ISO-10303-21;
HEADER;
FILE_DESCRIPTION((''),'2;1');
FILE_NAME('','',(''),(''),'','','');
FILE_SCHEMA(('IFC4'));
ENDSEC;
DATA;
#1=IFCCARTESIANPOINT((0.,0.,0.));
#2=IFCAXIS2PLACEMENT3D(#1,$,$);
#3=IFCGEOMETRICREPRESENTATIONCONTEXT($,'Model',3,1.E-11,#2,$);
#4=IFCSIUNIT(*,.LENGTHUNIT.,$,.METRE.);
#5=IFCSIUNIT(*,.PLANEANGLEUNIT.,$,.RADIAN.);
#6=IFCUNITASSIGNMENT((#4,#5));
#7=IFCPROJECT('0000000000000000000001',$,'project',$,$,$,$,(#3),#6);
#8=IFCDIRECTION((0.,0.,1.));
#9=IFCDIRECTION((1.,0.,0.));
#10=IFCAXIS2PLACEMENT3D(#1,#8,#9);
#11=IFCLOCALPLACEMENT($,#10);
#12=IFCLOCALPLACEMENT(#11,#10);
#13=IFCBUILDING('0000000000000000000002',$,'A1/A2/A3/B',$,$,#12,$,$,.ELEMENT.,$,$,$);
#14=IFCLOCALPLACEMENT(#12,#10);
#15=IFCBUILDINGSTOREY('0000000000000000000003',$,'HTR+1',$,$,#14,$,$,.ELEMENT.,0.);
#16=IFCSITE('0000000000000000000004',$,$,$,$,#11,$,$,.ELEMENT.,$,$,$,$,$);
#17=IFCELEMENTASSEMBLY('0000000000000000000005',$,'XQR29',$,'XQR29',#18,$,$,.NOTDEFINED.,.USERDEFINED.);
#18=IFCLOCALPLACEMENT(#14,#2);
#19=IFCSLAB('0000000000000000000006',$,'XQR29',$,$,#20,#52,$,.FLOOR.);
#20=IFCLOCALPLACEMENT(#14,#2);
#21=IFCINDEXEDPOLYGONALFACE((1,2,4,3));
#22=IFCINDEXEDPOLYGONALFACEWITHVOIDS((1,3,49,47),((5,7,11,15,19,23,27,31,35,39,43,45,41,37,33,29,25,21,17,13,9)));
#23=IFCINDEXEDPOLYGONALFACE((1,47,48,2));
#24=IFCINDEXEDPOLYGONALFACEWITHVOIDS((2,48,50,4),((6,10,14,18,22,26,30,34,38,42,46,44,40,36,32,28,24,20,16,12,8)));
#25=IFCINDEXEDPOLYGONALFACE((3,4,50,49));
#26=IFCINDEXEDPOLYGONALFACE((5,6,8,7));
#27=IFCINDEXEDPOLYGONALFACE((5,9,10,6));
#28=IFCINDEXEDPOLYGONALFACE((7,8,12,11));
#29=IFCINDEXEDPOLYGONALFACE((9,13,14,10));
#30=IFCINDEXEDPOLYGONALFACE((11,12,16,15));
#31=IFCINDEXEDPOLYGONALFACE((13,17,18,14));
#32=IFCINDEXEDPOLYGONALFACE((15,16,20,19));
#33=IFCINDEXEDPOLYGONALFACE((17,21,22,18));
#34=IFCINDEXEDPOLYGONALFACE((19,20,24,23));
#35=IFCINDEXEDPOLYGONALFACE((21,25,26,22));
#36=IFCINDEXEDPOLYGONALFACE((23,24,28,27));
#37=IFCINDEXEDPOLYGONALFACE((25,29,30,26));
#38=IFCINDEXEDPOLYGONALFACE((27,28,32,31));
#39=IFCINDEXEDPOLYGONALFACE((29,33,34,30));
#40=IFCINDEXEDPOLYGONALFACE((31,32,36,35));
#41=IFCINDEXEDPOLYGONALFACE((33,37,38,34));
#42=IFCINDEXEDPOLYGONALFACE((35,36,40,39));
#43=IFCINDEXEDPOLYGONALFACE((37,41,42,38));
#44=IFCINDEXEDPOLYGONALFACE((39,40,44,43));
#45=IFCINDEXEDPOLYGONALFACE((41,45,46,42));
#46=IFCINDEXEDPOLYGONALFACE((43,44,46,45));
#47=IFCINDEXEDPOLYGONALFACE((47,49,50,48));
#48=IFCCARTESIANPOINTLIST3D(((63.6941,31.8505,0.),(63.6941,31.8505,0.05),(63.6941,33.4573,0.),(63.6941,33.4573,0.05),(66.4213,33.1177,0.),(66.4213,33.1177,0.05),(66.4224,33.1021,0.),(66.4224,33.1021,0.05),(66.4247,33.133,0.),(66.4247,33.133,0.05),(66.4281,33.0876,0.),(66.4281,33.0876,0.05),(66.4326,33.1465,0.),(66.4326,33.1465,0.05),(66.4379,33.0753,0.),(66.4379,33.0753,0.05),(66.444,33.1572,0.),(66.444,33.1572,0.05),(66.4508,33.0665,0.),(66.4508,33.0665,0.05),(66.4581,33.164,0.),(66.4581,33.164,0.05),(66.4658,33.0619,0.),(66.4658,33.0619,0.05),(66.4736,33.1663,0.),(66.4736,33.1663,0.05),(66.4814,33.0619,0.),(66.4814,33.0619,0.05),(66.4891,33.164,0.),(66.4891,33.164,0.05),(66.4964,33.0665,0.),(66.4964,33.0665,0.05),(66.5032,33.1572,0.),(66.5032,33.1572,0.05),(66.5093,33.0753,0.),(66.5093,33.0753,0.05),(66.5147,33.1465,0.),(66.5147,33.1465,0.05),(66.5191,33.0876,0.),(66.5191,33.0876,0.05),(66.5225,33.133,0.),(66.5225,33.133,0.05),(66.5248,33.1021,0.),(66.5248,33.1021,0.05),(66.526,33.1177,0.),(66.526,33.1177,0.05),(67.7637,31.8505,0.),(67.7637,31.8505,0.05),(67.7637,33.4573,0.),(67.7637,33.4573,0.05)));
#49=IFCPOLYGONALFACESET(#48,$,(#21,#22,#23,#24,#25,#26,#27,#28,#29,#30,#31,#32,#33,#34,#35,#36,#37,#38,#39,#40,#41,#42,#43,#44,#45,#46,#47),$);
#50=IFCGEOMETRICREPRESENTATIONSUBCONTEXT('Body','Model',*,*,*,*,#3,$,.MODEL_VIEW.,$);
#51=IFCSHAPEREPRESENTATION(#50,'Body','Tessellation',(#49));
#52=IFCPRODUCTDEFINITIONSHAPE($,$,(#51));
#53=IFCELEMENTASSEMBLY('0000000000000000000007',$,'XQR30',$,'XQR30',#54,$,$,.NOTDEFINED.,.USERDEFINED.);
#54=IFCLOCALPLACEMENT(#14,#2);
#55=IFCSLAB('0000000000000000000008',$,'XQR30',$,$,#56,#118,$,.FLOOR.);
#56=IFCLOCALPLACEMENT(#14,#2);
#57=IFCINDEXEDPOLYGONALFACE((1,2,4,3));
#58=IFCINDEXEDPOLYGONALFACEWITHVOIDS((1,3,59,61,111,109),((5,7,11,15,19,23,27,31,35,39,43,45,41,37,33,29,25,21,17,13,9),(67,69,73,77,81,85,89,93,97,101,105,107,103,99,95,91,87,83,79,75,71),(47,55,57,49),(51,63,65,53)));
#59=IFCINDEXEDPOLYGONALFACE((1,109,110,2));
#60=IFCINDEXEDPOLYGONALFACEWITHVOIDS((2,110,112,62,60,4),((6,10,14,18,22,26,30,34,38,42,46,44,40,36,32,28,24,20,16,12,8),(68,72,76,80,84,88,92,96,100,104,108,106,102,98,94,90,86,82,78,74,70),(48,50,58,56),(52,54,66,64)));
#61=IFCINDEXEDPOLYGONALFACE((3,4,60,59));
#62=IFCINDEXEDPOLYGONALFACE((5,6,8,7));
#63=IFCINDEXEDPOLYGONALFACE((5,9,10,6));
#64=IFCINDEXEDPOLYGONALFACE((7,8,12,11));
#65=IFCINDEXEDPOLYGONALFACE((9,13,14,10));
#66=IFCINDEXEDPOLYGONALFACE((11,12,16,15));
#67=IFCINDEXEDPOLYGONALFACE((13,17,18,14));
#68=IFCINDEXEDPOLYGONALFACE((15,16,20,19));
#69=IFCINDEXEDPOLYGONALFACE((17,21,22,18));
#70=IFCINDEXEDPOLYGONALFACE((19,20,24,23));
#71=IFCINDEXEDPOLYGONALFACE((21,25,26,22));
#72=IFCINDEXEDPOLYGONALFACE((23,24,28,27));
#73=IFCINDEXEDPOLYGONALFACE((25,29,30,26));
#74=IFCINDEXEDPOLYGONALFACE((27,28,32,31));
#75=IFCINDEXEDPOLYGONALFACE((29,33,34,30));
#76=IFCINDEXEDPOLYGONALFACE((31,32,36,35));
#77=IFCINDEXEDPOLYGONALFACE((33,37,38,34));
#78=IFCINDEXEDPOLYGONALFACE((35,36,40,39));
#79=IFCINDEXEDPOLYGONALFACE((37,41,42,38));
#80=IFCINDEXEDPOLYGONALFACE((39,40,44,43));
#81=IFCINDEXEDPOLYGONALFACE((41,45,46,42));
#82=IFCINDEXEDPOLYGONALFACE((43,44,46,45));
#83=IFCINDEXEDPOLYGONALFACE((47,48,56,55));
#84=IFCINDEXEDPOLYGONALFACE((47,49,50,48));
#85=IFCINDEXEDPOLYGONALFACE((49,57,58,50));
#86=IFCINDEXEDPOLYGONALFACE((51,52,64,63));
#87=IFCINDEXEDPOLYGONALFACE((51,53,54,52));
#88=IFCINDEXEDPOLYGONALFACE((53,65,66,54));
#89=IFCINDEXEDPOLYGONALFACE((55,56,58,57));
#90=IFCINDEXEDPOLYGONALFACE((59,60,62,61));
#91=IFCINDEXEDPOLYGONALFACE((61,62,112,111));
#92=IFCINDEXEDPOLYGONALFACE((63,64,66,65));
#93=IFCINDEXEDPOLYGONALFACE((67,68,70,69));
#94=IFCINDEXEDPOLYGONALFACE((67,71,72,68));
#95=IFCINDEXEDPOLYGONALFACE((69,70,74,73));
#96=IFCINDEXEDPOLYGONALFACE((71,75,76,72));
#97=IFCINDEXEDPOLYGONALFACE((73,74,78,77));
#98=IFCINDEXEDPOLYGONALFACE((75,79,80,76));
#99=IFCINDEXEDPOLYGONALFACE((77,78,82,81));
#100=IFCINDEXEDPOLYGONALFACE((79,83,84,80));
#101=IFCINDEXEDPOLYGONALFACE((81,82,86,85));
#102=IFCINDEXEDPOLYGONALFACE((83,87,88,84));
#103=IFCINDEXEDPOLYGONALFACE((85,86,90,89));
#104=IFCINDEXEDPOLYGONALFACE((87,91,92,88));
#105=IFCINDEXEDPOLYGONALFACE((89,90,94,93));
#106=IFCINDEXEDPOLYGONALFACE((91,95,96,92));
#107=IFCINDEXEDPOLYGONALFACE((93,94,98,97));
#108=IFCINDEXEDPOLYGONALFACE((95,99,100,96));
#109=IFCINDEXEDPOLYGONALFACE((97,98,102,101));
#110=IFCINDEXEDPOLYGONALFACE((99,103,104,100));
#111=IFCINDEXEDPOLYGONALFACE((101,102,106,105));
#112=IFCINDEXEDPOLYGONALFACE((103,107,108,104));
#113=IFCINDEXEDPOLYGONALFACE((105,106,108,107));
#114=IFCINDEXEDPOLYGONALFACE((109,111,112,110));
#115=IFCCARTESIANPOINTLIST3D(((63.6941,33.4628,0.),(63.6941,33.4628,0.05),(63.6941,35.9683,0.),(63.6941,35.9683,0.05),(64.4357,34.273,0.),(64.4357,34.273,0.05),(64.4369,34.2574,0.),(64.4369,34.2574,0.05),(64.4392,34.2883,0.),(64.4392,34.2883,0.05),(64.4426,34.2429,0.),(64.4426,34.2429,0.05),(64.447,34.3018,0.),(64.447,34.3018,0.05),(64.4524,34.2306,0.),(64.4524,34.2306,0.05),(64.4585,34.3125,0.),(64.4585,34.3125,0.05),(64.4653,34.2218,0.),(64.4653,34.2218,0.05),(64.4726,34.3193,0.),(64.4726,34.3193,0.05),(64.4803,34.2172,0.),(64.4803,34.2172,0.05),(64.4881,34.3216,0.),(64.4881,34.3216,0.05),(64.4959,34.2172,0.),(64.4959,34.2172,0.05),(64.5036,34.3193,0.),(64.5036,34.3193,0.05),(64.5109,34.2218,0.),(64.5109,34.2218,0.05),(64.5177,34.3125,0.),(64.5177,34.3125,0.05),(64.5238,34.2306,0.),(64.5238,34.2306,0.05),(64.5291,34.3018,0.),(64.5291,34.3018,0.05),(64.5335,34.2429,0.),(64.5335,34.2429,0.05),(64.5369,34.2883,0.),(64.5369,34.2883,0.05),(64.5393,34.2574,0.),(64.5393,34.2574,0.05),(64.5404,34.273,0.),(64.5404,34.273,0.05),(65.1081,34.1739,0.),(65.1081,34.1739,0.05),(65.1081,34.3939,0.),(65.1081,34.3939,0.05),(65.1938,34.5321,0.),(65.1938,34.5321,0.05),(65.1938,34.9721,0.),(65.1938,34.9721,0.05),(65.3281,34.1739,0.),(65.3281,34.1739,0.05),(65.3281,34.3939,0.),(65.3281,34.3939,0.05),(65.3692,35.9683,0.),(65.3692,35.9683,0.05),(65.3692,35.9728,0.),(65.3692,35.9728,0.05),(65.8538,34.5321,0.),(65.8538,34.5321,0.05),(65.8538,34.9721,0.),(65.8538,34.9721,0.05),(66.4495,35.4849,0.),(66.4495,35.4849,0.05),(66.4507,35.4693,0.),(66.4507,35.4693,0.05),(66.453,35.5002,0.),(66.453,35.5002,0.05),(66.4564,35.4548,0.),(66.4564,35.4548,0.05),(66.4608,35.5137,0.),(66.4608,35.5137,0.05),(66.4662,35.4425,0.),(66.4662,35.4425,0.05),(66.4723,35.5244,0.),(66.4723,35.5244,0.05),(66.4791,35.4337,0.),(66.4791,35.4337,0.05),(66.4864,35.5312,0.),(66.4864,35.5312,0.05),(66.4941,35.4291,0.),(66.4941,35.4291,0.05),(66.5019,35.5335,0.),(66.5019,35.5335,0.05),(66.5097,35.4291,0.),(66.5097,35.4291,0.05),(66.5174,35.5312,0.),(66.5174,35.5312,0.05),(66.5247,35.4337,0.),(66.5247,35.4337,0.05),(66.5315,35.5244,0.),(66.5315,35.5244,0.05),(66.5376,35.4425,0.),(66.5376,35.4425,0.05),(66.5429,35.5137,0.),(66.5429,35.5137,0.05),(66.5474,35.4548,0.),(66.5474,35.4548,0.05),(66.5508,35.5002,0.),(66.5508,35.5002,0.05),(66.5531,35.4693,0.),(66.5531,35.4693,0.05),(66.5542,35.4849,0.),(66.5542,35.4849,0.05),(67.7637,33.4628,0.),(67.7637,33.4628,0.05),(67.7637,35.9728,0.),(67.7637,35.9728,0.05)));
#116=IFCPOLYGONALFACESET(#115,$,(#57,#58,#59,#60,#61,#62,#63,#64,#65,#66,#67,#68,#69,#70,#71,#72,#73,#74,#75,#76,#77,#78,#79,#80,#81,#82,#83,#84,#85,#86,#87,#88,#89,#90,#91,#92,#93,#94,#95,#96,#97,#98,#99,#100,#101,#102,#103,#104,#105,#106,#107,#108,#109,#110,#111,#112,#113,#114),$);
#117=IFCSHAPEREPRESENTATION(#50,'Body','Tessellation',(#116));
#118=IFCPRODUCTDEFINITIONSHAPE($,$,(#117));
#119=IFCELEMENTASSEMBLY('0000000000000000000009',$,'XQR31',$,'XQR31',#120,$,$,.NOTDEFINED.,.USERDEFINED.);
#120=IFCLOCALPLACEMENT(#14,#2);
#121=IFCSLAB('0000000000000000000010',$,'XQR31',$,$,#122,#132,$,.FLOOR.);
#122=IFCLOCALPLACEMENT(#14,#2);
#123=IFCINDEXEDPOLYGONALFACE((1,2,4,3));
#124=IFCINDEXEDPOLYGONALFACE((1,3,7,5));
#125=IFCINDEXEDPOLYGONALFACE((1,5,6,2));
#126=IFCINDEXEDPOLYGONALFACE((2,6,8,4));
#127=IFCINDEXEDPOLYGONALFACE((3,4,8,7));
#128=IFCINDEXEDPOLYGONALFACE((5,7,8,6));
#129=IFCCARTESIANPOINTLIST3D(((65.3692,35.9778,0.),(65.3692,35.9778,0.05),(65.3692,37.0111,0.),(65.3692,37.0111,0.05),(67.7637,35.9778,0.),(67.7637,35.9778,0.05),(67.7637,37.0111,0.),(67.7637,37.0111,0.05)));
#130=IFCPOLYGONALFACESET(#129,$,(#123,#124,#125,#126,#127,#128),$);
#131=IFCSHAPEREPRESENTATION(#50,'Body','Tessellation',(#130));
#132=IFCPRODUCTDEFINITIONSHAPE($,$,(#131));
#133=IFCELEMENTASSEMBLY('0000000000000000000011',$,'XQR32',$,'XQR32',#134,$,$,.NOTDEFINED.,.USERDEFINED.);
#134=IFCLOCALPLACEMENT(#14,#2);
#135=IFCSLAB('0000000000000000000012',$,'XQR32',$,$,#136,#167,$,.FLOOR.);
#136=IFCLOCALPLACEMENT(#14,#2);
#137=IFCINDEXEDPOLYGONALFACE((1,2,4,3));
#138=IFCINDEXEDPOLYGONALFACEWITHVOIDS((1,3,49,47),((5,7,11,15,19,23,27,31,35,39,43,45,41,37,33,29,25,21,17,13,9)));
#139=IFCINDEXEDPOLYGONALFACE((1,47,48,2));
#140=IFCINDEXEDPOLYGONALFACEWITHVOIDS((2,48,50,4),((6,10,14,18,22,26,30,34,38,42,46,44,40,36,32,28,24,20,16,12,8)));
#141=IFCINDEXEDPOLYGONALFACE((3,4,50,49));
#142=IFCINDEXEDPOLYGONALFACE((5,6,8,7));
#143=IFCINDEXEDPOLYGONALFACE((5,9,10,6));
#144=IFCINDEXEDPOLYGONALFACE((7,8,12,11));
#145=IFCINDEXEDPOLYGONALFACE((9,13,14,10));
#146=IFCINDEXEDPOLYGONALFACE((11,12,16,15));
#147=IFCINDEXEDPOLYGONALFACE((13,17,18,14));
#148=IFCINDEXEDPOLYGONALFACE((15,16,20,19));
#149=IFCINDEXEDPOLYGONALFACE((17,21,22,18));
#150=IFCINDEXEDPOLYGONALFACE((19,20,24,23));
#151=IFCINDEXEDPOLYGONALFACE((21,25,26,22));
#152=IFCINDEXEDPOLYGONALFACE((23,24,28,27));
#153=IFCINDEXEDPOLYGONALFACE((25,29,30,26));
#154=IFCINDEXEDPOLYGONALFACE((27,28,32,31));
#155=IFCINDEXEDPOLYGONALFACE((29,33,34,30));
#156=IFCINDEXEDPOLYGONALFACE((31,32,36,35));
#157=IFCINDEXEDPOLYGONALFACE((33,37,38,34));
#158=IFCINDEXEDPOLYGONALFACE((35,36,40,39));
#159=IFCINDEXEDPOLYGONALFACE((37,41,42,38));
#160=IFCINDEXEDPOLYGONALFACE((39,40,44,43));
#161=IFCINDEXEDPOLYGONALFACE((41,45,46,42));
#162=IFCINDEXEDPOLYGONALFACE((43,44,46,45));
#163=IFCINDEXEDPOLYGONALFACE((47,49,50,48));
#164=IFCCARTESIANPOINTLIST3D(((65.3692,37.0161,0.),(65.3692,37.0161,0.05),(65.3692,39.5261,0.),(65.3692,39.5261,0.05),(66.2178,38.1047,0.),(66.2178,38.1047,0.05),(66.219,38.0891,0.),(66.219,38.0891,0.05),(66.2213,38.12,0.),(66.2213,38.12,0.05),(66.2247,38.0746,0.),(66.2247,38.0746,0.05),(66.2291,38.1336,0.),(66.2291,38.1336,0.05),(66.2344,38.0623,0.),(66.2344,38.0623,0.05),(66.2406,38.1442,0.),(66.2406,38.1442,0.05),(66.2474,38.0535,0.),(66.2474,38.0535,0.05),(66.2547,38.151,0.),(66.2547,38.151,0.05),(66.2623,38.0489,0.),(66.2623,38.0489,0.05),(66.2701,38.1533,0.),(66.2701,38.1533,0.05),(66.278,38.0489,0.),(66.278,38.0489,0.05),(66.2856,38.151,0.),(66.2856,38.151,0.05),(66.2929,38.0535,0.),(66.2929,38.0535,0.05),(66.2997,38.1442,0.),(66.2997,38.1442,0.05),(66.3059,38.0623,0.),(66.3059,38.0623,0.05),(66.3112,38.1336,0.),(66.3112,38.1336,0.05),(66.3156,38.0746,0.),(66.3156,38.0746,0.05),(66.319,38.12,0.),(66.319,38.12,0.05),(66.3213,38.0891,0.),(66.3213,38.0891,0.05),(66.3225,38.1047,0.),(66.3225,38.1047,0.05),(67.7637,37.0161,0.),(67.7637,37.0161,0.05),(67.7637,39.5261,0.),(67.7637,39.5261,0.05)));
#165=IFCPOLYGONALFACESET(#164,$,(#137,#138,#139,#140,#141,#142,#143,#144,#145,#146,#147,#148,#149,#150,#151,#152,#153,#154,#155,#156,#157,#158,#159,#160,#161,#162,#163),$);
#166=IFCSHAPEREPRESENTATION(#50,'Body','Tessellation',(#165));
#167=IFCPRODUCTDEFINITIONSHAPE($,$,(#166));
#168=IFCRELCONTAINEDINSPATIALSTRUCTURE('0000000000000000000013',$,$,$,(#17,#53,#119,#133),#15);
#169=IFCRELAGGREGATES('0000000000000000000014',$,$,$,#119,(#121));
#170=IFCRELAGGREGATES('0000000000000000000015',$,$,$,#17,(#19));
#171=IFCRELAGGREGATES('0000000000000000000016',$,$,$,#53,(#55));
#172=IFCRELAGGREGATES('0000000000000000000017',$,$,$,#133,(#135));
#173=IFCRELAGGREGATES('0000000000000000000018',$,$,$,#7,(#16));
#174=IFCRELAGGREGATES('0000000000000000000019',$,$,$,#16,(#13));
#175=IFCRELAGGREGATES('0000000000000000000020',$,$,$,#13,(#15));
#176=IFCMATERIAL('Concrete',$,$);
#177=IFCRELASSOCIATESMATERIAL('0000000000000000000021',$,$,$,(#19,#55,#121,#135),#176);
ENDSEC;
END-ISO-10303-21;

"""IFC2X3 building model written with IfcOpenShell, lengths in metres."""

from ifc_helpers import new_model, si_unit, frame, origin, origin_with_axes, origin_2d_with_axis, place, context, subcontext, project, spatial, polyline, circle, outline, extrude, material, element, aggregate, save


model = new_model("IFC2X3")

# Units and contexts
model_context = context("Model", 3, precision=1e-11, world=origin())
body_context = subcontext(model_context, "Body", "Model", "MODEL_VIEW")
ifc_project = project(units=[si_unit("LENGTHUNIT", "METRE"), si_unit("PLANEANGLEUNIT", "RADIAN")], contexts=[model_context])

# Site, building, storey
site_placement = place(None, origin_with_axes())
site = spatial("IfcSite", under=ifc_project, at=site_placement, CompositionType="ELEMENT")
building_placement = place(site_placement, origin_with_axes())
building = spatial("IfcBuilding", under=site, at=building_placement, Name="A1/A2/A3/B", CompositionType="ELEMENT")
storey_placement = place(building_placement, origin_with_axes())
storey = spatial("IfcBuildingStorey", under=building, at=storey_placement, Name="HTR+1", CompositionType="ELEMENT", Elevation=0.0)

# Element assembly, slab, opening
assembly_1_placement = place(storey_placement, origin_with_axes())
assembly_1 = element("IfcElementAssembly", 1, at=assembly_1_placement, inside=storey, Name="XQR29", ObjectType="XQR29", AssemblyPlace="NOTDEFINED", PredefinedType="USERDEFINED")
ifc_material = material(Name="Concrete")
slab_1_placement = place(assembly_1_placement, frame((63.6941, 31.8505, 0.0), z_axis=(0.0, 0.0, 1.0), x_axis=(1.0, 0.0, 0.0)))
slab_1 = element("IfcSlab", 2, at=slab_1_placement, material=ifc_material, Name="XQR29", PredefinedType="FLOOR", context=body_context, shape_type="SweptSolid", body=[
    extrude(outline(polyline([(0.0, 0.0), (0.0, -4.0697), (1.6068, -4.0697), (1.6068, 0.0), (0.0, 0.0)])), frame((0.0, 0.0, 0.0), z_axis=(0.0, 0.0, 1.0), x_axis=(0.0, 1.0, 0.0)), (0.0, 0.0, 1.0), 0.05),
])
opening_1_placement = place(slab_1_placement, frame((2.7795, 1.2633, 0.0), z_axis=(0.0, 0.0, 1.0), x_axis=(1.0, 0.0, 0.0)))
element("IfcOpeningElement", 3, at=opening_1_placement, cuts=slab_1, ObjectType="Opening", context=body_context, shape_type="SweptSolid", body=[
    extrude(circle(Radius=0.0525, at=origin_2d_with_axis()), frame((0.0, 0.0, 0.0), z_axis=(0.0, 0.0, 1.0), x_axis=(0.0, 1.0, 0.0)), (0.0, 0.0, 1.0), 0.05),
])

# Element assembly, slab, openings
assembly_2_placement = place(storey_placement, origin_with_axes())
assembly_2 = element("IfcElementAssembly", 4, at=assembly_2_placement, inside=storey, Name="XQR30", ObjectType="XQR30", AssemblyPlace="NOTDEFINED", PredefinedType="USERDEFINED")
slab_2_placement = place(assembly_2_placement, frame((63.6941, 33.4628, 0.0), z_axis=(0.0, 0.0, 1.0), x_axis=(1.0, 0.0, 0.0)))
slab_2 = element("IfcSlab", 5, at=slab_2_placement, material=ifc_material, Name="XQR30", PredefinedType="FLOOR", context=body_context, shape_type="SweptSolid", body=[
    extrude(outline(polyline([(0.0, 0.0), (0.0, -4.0697), (2.51, -4.0697), (2.51, -1.6751), (2.5055, -1.6751), (2.5055, 0.0), (0.0, 0.0)])), frame((0.0, 0.0, 0.0), z_axis=(0.0, 0.0, 1.0), x_axis=(0.0, 1.0, 0.0)), (0.0, 0.0, 1.0), 0.05),
])
opening_2_placement = place(slab_2_placement, origin_with_axes())
element("IfcOpeningElement", 6, at=opening_2_placement, cuts=slab_2, ObjectType="Opening", context=body_context, shape_type="SweptSolid", body=[
    extrude(outline(polyline([(1.0693, -1.4997), (1.0693, -2.1597), (1.5093, -2.1597), (1.5093, -1.4997), (1.0693, -1.4997)])), frame((0.0, 0.0, 0.0), z_axis=(0.0, 0.0, 1.0), x_axis=(0.0, 1.0, 0.0)), (0.0, 0.0, 1.0), 0.05),
])
opening_3_placement = place(slab_2_placement, origin_with_axes())
element("IfcOpeningElement", 7, at=opening_3_placement, cuts=slab_2, ObjectType="Opening", context=body_context, shape_type="SweptSolid", body=[
    extrude(outline(polyline([(0.7111, -1.414), (0.7111, -1.634), (0.9311, -1.634), (0.9311, -1.414), (0.7111, -1.414)])), frame((0.0, 0.0, 0.0), z_axis=(0.0, 0.0, 1.0), x_axis=(0.0, 1.0, 0.0)), (0.0, 0.0, 1.0), 0.05),
])
opening_4_placement = place(slab_2_placement, frame((2.8078, 2.0182, 0.0), z_axis=(0.0, 0.0, 1.0), x_axis=(1.0, 0.0, 0.0)))
element("IfcOpeningElement", 8, at=opening_4_placement, cuts=slab_2, ObjectType="Opening", context=body_context, shape_type="SweptSolid", body=[
    extrude(circle(Radius=0.0525, at=origin_2d_with_axis()), frame((0.0, 0.0, 0.0), z_axis=(0.0, 0.0, 1.0), x_axis=(0.0, 1.0, 0.0)), (0.0, 0.0, 1.0), 0.05),
])
opening_5_placement = place(slab_2_placement, frame((0.794, 0.8063, 0.0), z_axis=(0.0, 0.0, 1.0), x_axis=(1.0, 0.0, 0.0)))
element("IfcOpeningElement", 9, at=opening_5_placement, cuts=slab_2, ObjectType="Opening", context=body_context, shape_type="SweptSolid", body=[
    extrude(circle(Radius=0.0525, at=origin_2d_with_axis()), frame((0.0, 0.0, 0.0), z_axis=(0.0, 0.0, 1.0), x_axis=(0.0, 1.0, 0.0)), (0.0, 0.0, 1.0), 0.05),
])

# Element assembly, slab
assembly_3_placement = place(storey_placement, origin_with_axes())
assembly_3 = element("IfcElementAssembly", 10, at=assembly_3_placement, inside=storey, Name="XQR31", ObjectType="XQR31", AssemblyPlace="NOTDEFINED", PredefinedType="USERDEFINED")
slab_3_placement = place(assembly_3_placement, frame((65.3692, 35.9778, 0.0), z_axis=(0.0, 0.0, 1.0), x_axis=(1.0, 0.0, 0.0)))
slab_3 = element("IfcSlab", 11, at=slab_3_placement, material=ifc_material, Name="XQR31", PredefinedType="FLOOR", context=body_context, shape_type="SweptSolid", body=[
    extrude(outline(polyline([(0.0, 0.0), (0.0, -2.3946), (1.0333, -2.3946), (1.0333, 0.0), (0.0, 0.0)])), frame((0.0, 0.0, 0.0), z_axis=(0.0, 0.0, 1.0), x_axis=(0.0, 1.0, 0.0)), (0.0, 0.0, 1.0), 0.05),
])
aggregate(assembly_3, [slab_3])

# Element assembly, slab, opening
assembly_4_placement = place(storey_placement, origin_with_axes())
assembly_4 = element("IfcElementAssembly", 12, at=assembly_4_placement, inside=storey, Name="XQR32", ObjectType="XQR32", AssemblyPlace="NOTDEFINED", PredefinedType="USERDEFINED")
slab_4_placement = place(assembly_4_placement, frame((65.3692, 37.0161, 0.0), z_axis=(0.0, 0.0, 1.0), x_axis=(1.0, 0.0, 0.0)))
slab_4 = element("IfcSlab", 13, at=slab_4_placement, material=ifc_material, Name="XQR32", PredefinedType="FLOOR", context=body_context, shape_type="SweptSolid", body=[
    extrude(outline(polyline([(0.0, 0.0), (0.0, -2.3946), (2.51, -2.3946), (2.51, 0.0), (0.0, 0.0)])), frame((0.0, 0.0, 0.0), z_axis=(0.0, 0.0, 1.0), x_axis=(0.0, 1.0, 0.0)), (0.0, 0.0, 1.0), 0.05),
])
opening_6_placement = place(slab_4_placement, frame((0.901, 1.0847, 0.0), z_axis=(0.0, 0.0, 1.0), x_axis=(1.0, 0.0, 0.0)))
element("IfcOpeningElement", 14, at=opening_6_placement, cuts=slab_4, ObjectType="Opening", context=body_context, shape_type="SweptSolid", body=[
    extrude(circle(Radius=0.0525, at=origin_2d_with_axis()), frame((0.0, 0.0, 0.0), z_axis=(0.0, 0.0, 1.0), x_axis=(0.0, 1.0, 0.0)), (0.0, 0.0, 1.0), 0.05),
])

aggregate(assembly_1, [slab_1])

aggregate(assembly_2, [slab_2])

aggregate(assembly_4, [slab_4])

save(model, "model.ifc")
